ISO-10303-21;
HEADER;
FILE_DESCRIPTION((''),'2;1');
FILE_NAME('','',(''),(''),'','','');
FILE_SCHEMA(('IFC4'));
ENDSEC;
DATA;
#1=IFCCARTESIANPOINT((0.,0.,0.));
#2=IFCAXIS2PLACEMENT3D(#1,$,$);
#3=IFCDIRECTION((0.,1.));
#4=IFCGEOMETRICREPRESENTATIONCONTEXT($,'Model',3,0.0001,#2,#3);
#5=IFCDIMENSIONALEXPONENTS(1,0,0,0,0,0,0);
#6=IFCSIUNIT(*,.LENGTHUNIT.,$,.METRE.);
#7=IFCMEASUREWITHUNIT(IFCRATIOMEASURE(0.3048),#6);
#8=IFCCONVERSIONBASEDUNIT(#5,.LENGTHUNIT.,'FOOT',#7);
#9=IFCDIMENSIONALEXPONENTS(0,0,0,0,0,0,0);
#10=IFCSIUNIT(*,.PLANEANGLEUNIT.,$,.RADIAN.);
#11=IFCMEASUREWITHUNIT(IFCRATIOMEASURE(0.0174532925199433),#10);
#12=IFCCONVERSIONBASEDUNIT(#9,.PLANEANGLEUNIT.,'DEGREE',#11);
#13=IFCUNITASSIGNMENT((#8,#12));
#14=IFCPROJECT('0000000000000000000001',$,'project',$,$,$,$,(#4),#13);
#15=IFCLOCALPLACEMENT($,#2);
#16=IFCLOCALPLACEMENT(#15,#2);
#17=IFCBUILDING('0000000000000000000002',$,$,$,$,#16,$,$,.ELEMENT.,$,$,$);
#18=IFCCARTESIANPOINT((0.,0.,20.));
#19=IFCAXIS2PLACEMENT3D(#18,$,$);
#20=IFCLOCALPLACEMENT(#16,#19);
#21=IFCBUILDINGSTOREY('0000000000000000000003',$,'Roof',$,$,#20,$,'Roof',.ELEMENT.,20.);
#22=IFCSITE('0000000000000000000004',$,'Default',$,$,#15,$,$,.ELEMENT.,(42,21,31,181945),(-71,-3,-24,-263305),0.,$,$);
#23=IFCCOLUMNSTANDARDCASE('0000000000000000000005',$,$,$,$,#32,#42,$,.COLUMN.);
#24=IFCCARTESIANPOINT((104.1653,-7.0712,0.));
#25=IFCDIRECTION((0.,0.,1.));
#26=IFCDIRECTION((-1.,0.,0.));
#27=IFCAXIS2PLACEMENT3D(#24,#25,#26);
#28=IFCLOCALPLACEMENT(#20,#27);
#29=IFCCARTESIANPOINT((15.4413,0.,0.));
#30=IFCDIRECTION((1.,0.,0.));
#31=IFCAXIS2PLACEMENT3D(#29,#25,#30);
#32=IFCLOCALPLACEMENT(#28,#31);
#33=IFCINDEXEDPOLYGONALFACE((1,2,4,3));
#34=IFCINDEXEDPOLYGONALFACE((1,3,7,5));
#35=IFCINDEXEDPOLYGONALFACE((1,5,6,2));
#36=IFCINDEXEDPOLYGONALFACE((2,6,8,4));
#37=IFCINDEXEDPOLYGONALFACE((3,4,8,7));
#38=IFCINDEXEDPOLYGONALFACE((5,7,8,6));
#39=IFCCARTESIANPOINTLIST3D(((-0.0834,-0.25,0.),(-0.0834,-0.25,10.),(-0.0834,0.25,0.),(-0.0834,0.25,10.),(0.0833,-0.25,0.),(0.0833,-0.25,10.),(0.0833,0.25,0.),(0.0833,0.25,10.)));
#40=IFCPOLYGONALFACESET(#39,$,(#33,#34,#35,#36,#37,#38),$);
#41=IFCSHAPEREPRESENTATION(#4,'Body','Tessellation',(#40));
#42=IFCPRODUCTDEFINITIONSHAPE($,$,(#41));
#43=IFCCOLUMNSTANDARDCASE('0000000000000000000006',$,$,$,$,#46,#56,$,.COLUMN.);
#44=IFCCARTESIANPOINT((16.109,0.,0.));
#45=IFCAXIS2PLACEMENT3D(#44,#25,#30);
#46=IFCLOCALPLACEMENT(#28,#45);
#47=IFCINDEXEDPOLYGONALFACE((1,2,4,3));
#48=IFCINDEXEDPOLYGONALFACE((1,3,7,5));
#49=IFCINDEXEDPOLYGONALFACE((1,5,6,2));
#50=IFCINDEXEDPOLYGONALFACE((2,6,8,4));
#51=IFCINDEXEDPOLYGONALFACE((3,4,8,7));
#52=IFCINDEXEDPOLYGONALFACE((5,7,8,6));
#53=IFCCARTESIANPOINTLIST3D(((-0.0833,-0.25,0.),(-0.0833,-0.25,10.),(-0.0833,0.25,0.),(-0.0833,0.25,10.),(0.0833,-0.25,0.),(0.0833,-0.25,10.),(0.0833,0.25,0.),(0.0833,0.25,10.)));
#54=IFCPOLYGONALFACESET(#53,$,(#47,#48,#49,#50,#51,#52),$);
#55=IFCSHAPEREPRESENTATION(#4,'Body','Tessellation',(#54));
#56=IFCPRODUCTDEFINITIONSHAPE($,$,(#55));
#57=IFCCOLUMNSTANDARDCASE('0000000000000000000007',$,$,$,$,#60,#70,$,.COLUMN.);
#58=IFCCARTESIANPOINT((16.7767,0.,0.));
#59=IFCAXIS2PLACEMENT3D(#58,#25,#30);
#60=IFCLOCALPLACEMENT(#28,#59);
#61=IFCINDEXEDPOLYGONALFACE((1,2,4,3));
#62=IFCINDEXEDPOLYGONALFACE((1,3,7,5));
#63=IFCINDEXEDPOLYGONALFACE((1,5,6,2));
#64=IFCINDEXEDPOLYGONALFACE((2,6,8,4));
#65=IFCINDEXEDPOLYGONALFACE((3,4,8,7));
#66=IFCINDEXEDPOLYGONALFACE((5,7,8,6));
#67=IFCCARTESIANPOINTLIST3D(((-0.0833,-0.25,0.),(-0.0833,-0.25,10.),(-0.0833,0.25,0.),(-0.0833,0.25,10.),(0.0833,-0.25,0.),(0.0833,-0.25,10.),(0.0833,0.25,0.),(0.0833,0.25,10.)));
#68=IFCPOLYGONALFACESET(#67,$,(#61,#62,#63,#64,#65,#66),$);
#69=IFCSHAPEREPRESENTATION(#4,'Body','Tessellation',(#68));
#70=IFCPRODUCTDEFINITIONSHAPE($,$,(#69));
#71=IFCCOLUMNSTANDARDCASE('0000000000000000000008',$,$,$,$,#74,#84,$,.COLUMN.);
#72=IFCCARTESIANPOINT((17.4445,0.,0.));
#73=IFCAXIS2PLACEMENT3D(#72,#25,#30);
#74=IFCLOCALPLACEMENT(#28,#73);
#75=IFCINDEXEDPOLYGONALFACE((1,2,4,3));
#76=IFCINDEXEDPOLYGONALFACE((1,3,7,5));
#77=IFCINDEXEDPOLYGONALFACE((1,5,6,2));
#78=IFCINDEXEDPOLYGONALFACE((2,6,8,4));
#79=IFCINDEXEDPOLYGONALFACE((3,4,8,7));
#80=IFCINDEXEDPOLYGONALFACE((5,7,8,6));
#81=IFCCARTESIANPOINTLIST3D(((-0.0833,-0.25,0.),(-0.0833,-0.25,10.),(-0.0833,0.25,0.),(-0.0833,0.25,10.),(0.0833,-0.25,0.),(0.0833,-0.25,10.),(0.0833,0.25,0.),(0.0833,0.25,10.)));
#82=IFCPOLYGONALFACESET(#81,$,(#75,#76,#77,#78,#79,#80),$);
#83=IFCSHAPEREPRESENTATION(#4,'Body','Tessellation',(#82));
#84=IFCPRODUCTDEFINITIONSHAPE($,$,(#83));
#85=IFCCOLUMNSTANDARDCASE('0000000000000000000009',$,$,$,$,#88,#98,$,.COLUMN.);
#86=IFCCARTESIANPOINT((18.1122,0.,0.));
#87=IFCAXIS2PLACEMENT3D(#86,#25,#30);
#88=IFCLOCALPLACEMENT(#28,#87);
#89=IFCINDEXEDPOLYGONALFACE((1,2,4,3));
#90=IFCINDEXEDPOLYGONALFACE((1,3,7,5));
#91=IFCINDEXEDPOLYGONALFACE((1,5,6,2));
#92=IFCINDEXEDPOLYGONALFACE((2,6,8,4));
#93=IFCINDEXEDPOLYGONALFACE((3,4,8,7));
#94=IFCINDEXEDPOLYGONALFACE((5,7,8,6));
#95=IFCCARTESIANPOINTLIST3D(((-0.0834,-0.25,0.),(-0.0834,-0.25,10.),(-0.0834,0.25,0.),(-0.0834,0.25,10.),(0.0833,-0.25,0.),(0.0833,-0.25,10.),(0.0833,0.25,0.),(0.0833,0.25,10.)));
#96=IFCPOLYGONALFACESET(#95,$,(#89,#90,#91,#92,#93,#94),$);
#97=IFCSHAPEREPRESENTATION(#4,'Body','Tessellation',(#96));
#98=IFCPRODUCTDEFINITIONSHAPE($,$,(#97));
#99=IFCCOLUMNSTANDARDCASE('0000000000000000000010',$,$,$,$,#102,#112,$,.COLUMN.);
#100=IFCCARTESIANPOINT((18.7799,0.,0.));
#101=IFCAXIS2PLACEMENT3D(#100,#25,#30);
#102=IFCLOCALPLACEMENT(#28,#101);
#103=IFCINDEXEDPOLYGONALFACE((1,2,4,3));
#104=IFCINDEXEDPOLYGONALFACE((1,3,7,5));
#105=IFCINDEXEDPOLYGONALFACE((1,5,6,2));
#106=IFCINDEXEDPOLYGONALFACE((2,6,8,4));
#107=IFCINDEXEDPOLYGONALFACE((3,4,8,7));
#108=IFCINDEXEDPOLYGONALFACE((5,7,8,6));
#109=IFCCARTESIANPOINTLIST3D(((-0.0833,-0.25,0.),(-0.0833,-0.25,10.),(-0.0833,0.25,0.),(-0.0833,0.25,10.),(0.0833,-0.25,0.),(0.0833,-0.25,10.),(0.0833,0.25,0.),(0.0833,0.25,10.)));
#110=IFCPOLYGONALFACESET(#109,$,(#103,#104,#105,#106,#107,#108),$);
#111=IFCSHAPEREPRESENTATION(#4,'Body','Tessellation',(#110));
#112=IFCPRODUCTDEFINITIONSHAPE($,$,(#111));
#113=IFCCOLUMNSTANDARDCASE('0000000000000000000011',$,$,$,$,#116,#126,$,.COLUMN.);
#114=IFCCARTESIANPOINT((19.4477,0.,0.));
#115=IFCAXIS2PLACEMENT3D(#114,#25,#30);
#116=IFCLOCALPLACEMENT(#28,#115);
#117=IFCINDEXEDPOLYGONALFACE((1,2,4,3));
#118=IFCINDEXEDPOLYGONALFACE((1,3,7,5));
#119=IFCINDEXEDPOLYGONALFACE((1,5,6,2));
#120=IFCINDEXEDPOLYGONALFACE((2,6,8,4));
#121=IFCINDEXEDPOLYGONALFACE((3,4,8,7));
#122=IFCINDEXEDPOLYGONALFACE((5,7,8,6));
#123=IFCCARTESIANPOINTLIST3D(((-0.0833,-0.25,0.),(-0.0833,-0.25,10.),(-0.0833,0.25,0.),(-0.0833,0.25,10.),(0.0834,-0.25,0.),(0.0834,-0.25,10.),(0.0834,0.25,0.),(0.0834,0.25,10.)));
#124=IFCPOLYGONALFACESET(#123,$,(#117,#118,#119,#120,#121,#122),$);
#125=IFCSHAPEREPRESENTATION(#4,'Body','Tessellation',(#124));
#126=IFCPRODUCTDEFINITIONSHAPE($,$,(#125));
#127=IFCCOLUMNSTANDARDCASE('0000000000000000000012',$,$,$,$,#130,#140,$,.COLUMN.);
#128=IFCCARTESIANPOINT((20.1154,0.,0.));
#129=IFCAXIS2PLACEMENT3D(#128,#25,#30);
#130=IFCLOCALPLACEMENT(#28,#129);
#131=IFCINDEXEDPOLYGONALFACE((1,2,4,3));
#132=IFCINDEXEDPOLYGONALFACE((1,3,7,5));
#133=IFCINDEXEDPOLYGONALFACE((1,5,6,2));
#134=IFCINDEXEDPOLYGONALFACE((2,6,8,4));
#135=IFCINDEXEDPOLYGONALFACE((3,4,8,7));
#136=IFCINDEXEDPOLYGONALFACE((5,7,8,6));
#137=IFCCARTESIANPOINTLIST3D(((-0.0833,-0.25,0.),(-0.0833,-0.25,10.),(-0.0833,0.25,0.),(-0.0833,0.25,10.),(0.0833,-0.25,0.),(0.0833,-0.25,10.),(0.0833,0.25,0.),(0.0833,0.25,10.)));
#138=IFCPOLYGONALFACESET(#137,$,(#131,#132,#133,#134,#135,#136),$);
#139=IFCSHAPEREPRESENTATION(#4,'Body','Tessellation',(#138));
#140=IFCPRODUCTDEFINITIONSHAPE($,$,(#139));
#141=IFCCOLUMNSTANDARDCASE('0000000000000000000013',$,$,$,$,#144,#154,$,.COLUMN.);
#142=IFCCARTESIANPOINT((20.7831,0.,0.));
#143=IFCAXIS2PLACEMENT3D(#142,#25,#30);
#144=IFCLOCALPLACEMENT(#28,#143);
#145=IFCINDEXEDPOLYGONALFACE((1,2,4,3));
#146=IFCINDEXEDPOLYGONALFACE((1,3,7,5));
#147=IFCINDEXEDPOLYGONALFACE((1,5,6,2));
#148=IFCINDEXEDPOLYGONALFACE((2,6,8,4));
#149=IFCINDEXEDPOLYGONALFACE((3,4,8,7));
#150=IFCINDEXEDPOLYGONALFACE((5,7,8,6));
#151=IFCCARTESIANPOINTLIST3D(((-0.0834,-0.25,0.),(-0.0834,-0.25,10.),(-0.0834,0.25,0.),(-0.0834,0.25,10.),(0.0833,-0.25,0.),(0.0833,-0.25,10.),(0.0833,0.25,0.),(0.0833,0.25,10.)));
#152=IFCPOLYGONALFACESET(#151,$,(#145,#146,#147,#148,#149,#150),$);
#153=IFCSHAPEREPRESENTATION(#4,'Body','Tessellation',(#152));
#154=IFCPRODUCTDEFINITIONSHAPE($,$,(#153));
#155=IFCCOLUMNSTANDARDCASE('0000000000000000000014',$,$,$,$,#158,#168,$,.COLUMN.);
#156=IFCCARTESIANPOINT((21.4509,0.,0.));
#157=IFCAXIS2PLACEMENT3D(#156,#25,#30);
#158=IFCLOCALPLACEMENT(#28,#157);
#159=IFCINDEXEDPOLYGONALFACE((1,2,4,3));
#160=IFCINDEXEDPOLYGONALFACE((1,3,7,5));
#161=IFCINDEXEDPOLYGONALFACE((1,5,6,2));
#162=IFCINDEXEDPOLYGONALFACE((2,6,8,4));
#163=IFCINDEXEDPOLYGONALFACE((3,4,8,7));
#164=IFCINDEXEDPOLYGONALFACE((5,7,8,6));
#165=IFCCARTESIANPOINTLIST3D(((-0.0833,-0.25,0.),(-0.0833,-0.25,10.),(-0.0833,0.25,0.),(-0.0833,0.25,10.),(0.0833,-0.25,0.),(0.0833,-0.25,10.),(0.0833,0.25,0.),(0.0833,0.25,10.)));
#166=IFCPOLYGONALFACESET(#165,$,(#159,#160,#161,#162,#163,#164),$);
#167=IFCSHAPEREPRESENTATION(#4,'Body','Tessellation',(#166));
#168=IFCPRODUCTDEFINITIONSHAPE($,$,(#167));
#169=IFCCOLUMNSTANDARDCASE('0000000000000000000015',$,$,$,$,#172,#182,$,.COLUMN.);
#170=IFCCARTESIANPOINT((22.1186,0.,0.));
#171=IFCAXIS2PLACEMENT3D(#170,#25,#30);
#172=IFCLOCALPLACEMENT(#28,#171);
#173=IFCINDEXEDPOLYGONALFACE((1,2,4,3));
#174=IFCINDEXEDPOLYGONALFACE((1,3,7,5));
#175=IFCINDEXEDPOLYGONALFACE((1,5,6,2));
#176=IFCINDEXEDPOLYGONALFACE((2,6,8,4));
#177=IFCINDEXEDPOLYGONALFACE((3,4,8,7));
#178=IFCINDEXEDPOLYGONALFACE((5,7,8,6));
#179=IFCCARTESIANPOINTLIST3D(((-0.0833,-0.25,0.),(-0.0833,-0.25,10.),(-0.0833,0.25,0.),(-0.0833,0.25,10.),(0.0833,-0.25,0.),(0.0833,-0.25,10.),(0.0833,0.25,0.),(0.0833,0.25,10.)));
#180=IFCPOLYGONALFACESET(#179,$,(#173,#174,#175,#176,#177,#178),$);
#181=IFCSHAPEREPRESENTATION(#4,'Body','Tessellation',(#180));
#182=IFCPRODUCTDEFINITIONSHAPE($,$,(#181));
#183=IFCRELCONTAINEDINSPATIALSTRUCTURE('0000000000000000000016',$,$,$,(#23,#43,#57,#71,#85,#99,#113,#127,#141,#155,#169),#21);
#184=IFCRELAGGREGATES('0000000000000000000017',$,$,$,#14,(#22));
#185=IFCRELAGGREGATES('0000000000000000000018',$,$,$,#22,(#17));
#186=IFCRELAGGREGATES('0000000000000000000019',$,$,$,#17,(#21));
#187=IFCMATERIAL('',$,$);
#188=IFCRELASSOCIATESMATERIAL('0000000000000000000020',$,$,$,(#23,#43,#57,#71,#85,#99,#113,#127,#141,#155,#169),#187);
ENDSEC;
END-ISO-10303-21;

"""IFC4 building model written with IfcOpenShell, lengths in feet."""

from ifc_helpers import new_model, entity, si_unit, converted_unit, direction, frame, origin, place, context, project, spatial, rectangle, extrude, material, element, save


model = new_model("IFC4")

# Units and contexts
model_context = context("Model", 3, precision=0.0001, world=origin(), true_north=direction((0.0, 1.0)))
ifc_project = project(units=[converted_unit("LENGTHUNIT", "FOOT", entity("IfcRatioMeasure", 0.3048), si_unit("LENGTHUNIT", "METRE"), dimensions=[1, 0, 0, 0, 0, 0, 0]), converted_unit("PLANEANGLEUNIT", "DEGREE", entity("IfcRatioMeasure", 0.0174532925199433), si_unit("PLANEANGLEUNIT", "RADIAN"), dimensions=[0, 0, 0, 0, 0, 0, 0])], contexts=[model_context])

# Site, building, storey
site_placement = place(None, origin())
site = spatial("IfcSite", under=ifc_project, at=site_placement, Name="Default", CompositionType="ELEMENT", RefLatitude=(42, 21, 31, 181945), RefLongitude=(-71, -3, -24, -263305), RefElevation=0.0)
building_placement = place(site_placement, origin())
building = spatial("IfcBuilding", under=site, at=building_placement, CompositionType="ELEMENT")
storey_placement = place(building_placement, frame((0.0, 0.0, 20.0)))
storey = spatial("IfcBuildingStorey", under=building, at=storey_placement, Name="Roof", LongName="Roof", CompositionType="ELEMENT", Elevation=20.0)

# Columns
ifc_material = material(Name="")
placement = place(storey_placement, frame((104.1653, -7.0712, 0.0), z_axis=(0.0, 0.0, 1.0), x_axis=(-1.0, 0.0, 0.0)))
for number, where, z_axis, x_axis in (
    (1, (15.4413, 0.0, 0.0), (0.0, 0.0, 1.0), (1.0, 0.0, 0.0)),
    (2, (16.109, 0.0, 0.0), (0.0, 0.0, 1.0), (1.0, 0.0, 0.0)),
    (3, (16.7767, 0.0, 0.0), (0.0, 0.0, 1.0), (1.0, 0.0, 0.0)),
    (4, (17.4445, 0.0, 0.0), (0.0, 0.0, 1.0), (1.0, 0.0, 0.0)),
    (5, (18.1122, 0.0, 0.0), (0.0, 0.0, 1.0), (1.0, 0.0, 0.0)),
    (6, (18.7799, 0.0, 0.0), (0.0, 0.0, 1.0), (1.0, 0.0, 0.0)),
    (7, (19.4477, 0.0, 0.0), (0.0, 0.0, 1.0), (1.0, 0.0, 0.0)),
    (8, (20.1154, 0.0, 0.0), (0.0, 0.0, 1.0), (1.0, 0.0, 0.0)),
    (9, (20.7831, 0.0, 0.0), (0.0, 0.0, 1.0), (1.0, 0.0, 0.0)),
    (10, (21.4509, 0.0, 0.0), (0.0, 0.0, 1.0), (1.0, 0.0, 0.0)),
    (11, (22.1186, 0.0, 0.0), (0.0, 0.0, 1.0), (1.0, 0.0, 0.0)),
):
    element("IfcColumnStandardCase", number, at=place(placement, frame(where, z_axis=z_axis, x_axis=x_axis)), inside=storey, material=ifc_material, PredefinedType="COLUMN", context=model_context, shape_type="SweptSolid", body=[
        extrude(rectangle(XDim=0.1667, YDim=0.5), origin(), (0.0, 0.0, 1.0), 10.0),
    ])

save(model, "model.ifc")
